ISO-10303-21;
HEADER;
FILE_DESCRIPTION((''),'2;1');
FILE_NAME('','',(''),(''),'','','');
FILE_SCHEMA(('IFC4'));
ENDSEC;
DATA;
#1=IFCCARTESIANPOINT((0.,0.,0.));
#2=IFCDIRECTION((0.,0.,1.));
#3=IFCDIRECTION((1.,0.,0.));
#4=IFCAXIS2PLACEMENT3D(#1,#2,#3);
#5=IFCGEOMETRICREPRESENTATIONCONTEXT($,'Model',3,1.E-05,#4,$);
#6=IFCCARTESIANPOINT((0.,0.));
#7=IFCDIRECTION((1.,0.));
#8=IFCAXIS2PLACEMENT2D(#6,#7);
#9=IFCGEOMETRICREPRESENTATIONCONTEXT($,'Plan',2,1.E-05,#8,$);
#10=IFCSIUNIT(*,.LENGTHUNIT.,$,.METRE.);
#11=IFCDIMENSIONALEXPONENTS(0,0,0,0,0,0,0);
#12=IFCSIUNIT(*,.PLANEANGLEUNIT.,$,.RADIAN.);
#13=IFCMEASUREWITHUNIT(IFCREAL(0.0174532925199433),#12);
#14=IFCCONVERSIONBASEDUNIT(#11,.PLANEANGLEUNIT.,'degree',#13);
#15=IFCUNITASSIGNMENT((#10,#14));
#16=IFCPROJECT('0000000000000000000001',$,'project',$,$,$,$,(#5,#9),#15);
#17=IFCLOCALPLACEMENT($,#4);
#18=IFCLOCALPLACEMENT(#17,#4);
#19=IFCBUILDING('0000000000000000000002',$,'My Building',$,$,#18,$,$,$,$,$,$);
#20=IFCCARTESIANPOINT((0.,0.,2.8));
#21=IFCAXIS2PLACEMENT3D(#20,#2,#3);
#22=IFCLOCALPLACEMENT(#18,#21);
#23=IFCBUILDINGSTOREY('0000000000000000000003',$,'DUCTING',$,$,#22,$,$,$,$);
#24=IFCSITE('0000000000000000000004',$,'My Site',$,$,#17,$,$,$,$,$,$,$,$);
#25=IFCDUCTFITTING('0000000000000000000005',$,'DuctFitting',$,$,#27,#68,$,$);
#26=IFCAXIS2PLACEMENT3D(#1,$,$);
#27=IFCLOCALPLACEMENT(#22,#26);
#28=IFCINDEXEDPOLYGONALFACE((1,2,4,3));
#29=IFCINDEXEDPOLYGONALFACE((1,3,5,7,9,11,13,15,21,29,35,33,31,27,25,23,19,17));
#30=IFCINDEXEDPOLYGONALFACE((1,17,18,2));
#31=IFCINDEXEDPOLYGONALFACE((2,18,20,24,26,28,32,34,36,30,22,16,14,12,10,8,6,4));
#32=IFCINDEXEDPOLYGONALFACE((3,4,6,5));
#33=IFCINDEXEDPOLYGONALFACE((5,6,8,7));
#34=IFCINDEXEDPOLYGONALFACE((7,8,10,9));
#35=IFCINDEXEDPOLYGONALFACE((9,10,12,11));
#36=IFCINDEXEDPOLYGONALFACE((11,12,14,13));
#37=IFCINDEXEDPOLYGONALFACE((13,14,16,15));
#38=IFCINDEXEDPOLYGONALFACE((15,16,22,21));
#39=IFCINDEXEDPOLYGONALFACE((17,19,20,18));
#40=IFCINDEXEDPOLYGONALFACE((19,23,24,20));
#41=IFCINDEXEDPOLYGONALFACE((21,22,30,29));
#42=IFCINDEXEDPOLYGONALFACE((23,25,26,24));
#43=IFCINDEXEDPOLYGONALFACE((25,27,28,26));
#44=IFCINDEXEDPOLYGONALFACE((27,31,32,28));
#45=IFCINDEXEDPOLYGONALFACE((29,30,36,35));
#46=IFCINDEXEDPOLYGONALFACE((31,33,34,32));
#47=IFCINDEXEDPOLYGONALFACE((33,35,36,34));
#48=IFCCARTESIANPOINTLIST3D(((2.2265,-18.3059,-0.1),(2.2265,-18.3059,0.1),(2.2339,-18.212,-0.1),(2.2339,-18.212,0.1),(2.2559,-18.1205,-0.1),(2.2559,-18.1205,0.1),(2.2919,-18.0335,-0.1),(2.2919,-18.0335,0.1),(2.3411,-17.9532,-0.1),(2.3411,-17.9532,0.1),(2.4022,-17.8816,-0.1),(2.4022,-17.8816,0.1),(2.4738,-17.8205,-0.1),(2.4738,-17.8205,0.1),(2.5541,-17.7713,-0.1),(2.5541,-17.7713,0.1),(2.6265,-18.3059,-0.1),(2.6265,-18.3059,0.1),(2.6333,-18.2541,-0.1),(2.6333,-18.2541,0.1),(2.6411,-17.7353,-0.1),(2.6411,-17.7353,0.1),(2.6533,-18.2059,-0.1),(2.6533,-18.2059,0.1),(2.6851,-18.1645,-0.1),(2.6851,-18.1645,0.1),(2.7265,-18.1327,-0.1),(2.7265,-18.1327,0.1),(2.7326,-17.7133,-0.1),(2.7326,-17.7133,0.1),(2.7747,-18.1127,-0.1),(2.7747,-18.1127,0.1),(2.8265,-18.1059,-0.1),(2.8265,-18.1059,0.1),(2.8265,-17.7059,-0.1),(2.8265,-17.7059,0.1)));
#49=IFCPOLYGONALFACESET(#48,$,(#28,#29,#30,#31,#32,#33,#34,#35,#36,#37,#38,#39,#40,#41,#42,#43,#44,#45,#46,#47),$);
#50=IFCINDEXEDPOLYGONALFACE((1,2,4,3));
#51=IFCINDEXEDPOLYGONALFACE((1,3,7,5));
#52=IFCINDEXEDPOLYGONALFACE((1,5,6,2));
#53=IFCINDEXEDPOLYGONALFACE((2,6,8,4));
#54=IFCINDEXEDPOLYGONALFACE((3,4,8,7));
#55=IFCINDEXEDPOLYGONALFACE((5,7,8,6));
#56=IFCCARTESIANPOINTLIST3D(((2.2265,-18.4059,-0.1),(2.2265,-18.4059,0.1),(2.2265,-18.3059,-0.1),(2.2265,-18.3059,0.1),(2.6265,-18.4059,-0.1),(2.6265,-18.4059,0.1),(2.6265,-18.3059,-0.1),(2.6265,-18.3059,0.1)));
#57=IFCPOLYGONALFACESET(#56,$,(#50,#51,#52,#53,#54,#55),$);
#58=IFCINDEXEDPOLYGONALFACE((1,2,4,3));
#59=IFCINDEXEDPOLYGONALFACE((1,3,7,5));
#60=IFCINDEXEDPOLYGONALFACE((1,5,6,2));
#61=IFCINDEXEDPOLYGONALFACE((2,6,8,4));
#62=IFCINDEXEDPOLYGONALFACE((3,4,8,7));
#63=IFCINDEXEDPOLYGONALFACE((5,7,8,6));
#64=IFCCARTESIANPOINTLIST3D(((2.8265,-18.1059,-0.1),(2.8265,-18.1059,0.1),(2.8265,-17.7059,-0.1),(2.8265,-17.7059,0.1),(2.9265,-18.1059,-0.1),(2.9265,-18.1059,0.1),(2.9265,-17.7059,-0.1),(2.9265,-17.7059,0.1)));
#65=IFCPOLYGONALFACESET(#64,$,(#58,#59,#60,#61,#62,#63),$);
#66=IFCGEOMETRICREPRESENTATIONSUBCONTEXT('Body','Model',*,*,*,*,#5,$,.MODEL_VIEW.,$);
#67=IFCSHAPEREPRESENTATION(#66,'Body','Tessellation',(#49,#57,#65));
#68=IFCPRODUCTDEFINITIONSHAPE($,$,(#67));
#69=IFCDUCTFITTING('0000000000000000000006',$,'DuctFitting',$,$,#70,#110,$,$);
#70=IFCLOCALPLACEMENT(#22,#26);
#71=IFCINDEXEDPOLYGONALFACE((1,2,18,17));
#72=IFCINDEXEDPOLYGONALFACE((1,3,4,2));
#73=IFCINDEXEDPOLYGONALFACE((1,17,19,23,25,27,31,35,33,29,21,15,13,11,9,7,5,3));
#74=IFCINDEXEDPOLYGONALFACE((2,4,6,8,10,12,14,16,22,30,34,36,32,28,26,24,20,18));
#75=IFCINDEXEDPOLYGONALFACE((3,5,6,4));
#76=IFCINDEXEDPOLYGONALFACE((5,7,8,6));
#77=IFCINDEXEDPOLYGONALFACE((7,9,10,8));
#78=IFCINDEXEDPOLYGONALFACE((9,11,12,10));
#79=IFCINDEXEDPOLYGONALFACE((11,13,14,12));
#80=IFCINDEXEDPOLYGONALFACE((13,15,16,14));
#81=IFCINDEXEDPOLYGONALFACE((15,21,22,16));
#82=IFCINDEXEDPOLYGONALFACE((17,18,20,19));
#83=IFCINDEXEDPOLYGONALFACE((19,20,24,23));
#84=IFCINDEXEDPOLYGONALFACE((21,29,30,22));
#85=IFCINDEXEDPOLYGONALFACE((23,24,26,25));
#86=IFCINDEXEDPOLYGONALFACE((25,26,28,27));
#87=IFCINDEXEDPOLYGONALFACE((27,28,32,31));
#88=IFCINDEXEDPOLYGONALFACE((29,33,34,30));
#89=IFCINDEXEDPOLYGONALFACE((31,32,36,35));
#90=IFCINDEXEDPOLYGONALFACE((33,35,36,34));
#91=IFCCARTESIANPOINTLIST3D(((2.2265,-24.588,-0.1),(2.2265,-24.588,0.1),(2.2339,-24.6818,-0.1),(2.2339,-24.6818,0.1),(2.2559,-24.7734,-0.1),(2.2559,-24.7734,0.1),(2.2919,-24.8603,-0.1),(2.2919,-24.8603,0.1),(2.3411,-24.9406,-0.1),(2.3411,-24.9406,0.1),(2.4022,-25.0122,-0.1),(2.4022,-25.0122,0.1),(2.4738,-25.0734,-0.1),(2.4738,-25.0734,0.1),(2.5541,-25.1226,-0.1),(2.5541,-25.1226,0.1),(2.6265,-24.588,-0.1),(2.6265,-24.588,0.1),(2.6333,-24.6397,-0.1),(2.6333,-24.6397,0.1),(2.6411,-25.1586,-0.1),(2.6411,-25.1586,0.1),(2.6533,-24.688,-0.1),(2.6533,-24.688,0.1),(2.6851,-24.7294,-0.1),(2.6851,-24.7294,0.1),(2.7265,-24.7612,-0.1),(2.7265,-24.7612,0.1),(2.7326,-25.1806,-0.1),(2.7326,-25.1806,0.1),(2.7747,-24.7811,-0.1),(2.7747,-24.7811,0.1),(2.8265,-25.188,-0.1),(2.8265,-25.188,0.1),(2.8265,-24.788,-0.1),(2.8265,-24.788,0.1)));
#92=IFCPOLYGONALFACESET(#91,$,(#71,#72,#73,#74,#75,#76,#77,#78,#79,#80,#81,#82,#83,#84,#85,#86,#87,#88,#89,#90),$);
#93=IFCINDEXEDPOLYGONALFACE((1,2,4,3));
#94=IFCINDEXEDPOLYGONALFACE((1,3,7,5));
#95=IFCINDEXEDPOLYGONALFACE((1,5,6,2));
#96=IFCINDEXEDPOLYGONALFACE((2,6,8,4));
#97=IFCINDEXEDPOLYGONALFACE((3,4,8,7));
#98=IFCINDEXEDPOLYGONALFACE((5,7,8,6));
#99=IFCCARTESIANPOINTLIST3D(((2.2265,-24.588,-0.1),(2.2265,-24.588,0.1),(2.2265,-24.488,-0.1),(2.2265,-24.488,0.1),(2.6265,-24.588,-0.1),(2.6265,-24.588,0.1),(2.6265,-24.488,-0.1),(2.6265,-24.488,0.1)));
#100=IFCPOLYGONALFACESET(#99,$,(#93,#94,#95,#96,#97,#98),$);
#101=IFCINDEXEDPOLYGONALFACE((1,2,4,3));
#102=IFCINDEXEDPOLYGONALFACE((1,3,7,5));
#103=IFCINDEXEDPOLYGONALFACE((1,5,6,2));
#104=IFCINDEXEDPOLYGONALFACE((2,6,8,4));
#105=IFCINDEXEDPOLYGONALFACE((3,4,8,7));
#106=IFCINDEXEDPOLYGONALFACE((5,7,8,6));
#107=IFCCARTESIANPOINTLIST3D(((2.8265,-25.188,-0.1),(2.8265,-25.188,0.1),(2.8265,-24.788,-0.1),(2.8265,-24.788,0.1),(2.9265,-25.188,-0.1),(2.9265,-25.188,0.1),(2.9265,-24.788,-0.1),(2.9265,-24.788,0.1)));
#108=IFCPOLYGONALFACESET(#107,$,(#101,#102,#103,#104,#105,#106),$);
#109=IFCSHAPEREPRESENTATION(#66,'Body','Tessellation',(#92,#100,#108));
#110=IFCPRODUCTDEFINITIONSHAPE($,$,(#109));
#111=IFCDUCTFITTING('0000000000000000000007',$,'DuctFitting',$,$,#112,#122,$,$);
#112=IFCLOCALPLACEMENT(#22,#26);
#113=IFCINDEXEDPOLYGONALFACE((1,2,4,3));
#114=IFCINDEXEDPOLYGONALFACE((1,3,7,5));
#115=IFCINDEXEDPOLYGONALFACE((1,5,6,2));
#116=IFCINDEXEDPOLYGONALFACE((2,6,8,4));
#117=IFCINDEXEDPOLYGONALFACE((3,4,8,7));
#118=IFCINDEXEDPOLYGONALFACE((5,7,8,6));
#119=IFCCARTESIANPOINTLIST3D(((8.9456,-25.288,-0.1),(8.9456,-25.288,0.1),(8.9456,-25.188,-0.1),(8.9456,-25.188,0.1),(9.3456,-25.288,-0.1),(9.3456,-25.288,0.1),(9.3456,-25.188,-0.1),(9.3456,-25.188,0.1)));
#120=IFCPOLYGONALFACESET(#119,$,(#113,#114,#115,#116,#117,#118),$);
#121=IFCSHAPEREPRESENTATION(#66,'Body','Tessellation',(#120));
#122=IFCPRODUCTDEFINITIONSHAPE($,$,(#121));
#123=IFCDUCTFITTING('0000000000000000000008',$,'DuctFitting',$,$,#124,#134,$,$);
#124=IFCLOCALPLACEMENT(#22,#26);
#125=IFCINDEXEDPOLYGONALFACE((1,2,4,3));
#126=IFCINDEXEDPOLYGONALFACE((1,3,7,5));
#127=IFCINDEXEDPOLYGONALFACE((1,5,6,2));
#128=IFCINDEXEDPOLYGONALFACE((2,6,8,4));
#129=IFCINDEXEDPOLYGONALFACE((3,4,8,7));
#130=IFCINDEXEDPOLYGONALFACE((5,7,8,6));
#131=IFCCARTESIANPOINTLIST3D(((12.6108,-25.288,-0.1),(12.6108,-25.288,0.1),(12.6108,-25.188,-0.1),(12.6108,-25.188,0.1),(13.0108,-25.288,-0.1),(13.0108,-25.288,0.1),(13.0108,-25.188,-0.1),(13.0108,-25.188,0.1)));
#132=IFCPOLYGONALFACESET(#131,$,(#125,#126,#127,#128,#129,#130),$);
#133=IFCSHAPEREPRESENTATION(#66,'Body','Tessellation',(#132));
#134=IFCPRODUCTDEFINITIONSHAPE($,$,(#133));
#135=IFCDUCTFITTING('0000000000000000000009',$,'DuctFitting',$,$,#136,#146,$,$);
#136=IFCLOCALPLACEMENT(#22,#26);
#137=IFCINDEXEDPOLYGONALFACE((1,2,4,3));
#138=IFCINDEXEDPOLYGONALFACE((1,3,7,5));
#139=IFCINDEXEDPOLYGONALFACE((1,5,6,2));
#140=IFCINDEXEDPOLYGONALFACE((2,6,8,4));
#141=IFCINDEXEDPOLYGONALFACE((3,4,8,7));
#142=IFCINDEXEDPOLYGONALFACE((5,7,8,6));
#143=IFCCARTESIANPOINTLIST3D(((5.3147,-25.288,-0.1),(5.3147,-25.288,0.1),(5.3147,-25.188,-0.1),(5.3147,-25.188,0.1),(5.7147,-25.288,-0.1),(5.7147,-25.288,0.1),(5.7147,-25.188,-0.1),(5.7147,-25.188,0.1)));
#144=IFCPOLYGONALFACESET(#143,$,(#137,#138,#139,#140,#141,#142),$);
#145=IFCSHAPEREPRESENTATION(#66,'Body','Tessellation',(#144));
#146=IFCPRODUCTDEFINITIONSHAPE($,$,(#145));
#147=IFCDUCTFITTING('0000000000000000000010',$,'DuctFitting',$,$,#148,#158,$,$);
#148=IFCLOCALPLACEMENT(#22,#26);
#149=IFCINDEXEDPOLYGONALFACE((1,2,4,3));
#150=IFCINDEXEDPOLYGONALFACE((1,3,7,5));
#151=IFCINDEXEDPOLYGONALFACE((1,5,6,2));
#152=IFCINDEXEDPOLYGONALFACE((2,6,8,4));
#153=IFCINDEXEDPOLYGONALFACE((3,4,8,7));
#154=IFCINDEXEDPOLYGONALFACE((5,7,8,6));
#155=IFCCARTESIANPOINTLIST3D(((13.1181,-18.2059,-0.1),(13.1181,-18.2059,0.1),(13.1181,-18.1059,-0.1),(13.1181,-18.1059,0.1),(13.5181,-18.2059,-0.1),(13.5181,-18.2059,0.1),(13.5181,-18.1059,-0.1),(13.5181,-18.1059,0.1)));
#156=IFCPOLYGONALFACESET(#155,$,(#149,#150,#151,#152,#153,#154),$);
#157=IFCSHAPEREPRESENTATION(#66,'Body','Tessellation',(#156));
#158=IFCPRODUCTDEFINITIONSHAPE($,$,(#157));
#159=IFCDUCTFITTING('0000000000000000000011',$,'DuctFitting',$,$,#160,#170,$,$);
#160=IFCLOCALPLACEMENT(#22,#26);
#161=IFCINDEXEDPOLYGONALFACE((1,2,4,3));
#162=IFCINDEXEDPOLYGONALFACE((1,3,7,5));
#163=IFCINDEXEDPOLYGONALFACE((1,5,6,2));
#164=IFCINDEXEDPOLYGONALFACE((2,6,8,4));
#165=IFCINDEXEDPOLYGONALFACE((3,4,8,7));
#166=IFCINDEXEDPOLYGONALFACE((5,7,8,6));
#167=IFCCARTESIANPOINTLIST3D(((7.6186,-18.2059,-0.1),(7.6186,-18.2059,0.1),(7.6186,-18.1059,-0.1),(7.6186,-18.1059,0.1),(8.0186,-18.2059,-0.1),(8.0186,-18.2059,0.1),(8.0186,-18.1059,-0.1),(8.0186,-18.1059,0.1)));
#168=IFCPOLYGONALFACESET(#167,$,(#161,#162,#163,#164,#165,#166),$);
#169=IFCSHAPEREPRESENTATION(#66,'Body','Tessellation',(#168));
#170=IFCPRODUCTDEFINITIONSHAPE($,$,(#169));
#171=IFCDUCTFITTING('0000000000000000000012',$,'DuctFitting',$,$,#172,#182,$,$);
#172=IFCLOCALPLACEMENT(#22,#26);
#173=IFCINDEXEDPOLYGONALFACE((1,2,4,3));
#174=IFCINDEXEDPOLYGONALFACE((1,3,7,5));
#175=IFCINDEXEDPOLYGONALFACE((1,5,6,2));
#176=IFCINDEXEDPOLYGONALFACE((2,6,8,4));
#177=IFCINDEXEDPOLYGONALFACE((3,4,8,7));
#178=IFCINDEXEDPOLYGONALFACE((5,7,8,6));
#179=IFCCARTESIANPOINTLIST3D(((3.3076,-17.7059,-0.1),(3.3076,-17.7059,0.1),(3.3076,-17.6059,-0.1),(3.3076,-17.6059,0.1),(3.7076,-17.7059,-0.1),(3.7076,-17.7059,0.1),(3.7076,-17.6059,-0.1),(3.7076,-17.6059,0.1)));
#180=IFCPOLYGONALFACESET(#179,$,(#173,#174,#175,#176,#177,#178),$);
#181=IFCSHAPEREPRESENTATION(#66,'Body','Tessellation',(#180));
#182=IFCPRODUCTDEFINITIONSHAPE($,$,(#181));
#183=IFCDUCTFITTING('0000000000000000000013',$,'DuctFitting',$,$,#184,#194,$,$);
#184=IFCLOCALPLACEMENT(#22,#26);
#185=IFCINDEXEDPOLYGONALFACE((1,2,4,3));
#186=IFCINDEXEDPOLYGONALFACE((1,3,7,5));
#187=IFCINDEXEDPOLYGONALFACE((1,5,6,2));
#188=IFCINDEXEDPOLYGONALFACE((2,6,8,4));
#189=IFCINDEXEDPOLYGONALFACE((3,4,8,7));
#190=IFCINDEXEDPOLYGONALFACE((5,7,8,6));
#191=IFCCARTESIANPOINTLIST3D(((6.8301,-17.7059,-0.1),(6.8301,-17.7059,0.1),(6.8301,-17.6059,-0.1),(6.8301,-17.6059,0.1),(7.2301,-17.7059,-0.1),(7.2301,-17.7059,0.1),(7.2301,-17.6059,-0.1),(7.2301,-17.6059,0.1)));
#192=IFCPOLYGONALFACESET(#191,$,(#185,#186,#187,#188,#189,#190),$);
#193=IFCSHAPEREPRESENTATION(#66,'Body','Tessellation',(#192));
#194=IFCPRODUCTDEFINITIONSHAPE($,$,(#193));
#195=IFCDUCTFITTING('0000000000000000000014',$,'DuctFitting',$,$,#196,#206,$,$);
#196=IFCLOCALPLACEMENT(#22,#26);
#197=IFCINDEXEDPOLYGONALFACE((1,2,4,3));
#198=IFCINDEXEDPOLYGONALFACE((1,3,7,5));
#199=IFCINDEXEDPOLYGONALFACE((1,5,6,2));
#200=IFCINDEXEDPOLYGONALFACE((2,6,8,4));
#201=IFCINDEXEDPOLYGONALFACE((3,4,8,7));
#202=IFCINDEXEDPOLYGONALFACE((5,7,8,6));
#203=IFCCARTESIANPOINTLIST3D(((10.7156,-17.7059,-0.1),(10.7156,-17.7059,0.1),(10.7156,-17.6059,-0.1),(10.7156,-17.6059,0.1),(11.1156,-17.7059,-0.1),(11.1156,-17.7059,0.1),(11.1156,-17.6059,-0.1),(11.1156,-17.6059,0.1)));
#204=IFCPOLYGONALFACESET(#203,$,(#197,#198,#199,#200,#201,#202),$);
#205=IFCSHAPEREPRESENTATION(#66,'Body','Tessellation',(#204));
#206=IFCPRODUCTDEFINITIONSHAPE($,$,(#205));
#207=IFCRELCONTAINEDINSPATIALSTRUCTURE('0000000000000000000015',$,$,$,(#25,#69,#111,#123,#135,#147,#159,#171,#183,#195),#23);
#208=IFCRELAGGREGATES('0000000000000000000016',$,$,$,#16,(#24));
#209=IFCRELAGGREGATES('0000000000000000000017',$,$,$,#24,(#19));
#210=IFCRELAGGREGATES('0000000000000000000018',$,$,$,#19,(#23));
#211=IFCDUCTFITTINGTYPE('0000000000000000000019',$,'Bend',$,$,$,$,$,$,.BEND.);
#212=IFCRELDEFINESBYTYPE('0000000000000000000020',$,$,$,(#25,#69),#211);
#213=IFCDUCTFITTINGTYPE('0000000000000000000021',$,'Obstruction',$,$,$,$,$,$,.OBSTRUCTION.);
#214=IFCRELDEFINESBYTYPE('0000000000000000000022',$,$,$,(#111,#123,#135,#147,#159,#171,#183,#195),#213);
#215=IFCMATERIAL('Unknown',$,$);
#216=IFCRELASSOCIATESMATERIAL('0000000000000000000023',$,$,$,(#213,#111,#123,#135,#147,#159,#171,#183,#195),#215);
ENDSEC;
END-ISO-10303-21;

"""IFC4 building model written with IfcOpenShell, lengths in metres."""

from ifc_helpers import new_model, entity, si_unit, converted_unit, frame, origin_with_axes, origin_2d_with_axis, place, context, subcontext, project, spatial, line, arc, indexed_curve, rectangle, outline, extrude, source, transform, mapped, material, material_profile, profile_set, profile_usage, type_object, type_shapes, element, save


model = new_model("IFC4")

# Units and contexts
model_context = context("Model", 3, precision=1e-05, world=origin_with_axes())
plan_context = context("Plan", 2, precision=1e-05, world=origin_2d_with_axis())
body_context = subcontext(model_context, "Body", "Model", "MODEL_VIEW")
ifc_project = project(units=[si_unit("LENGTHUNIT", "METRE"), converted_unit("PLANEANGLEUNIT", "degree", entity("IfcReal", 0.0174532925199433), si_unit("PLANEANGLEUNIT", "RADIAN"), dimensions=[0, 0, 0, 0, 0, 0, 0])], contexts=[model_context, plan_context])

# Site, building, storey
site_placement = place(None, origin_with_axes())
site = spatial("IfcSite", under=ifc_project, at=site_placement, Name="My Site")
building_placement = place(site_placement, origin_with_axes())
building = spatial("IfcBuilding", under=site, at=building_placement, Name="My Building")
storey_placement = place(building_placement, frame((0.0, 0.0, 2.8), z_axis=(0.0, 0.0, 1.0), x_axis=(1.0, 0.0, 0.0)))
storey = spatial("IfcBuildingStorey", under=building, at=storey_placement, Name="DUCTING")

# Shared definitions
ifc_material = material(Name="Unknown")

# Duct fittings
duct_fitting_type_1 = type_object("IfcDuctFittingType", Name="Bend", PredefinedType="BEND")
shared_shape = source(origin_with_axes(), body_context, "Body", "SweptSolid", [
    extrude(outline(indexed_curve([(-0.2, 0.0), (-0.2586, -0.1414), (-0.4, -0.2), (-0.4, -0.6), (0.0243, -0.4243), (0.2, 0.0)], segments=[arc(1, 2, 3), line(3, 4), arc(4, 5, 6), line(6, 1)])), frame((0.0, -0.1, -0.1), z_axis=(0.0, -1.0, 0.0), x_axis=(1.0, 0.0, 0.0)), (0.0, 0.0, -1.0), 0.2),
    extrude(rectangle(XDim=0.4, YDim=0.2), origin_with_axes(), (0.0, 0.0, -1.0), 0.1),
    extrude(rectangle(XDim=0.4, YDim=0.2), frame((-0.4, 0.0, -0.5), z_axis=(-1.0, 0.0, 0.0), x_axis=(0.0, 0.0, -1.0)), (0.0, 0.0, 1.0), 0.1),
])
type_shapes(duct_fitting_type_1, [shared_shape])
for number, where, z_axis, x_axis, name in (
    (1, (2.4265, -18.4059, 0.0), (0.0, -1.0, 0.0), (-1.0, 0.0, 0.0), "DuctFitting"),
    (2, (2.4265, -24.488, 0.0), (0.0, 1.0, 0.0), (-1.0, 0.0, 0.0), "DuctFitting"),
):
    element("IfcDuctFitting", number, at=place(storey_placement, frame(where, z_axis=z_axis, x_axis=x_axis)), inside=storey, type_object=duct_fitting_type_1, Name=name, context=body_context, shape_type="MappedRepresentation", body=[
        mapped(shared_shape, transform((0.0, 0.0, 0.0), x_axis=(1.0, 0.0, 0.0), y_axis=(0.0, 1.0, 0.0), z_axis=(0.0, 0.0, 1.0), scale=1.0)),
    ])
ifc_material_profile_1 = material_profile(ifc_material, rectangle(XDim=0.4, YDim=0.2))
ifc_profile_set_1 = profile_set([ifc_material_profile_1])
ifc_profile_usage_1 = profile_usage(ifc_profile_set_1, cardinal=5)
duct_fitting_type_2 = type_object("IfcDuctFittingType", Name="Obstruction", PredefinedType="OBSTRUCTION", material=ifc_profile_set_1)
duct_fitting_1_placement = place(storey_placement, frame((9.1456, -25.288, 0.0), z_axis=(0.0, 1.0, 0.0), x_axis=(1.0, 0.0, 0.0)))
element("IfcDuctFitting", 3, at=duct_fitting_1_placement, inside=storey, type_object=duct_fitting_type_2, material=ifc_profile_usage_1, Name="DuctFitting", context=body_context, shape_type="SweptSolid", body=[
    extrude(rectangle(XDim=0.4, YDim=0.2), origin_with_axes(), (0.0, 0.0, 1.0), 0.1),
])
ifc_profile_usage_2 = profile_usage(ifc_profile_set_1, cardinal=5)
duct_fitting_2_placement = place(storey_placement, frame((12.8108, -25.288, 0.0), z_axis=(0.0, 1.0, 0.0), x_axis=(1.0, 0.0, 0.0)))
element("IfcDuctFitting", 4, at=duct_fitting_2_placement, inside=storey, type_object=duct_fitting_type_2, material=ifc_profile_usage_2, Name="DuctFitting", context=body_context, shape_type="SweptSolid", body=[
    extrude(rectangle(XDim=0.4, YDim=0.2), origin_with_axes(), (0.0, 0.0, 1.0), 0.1),
])
ifc_profile_usage_3 = profile_usage(ifc_profile_set_1, cardinal=5)
duct_fitting_3_placement = place(storey_placement, frame((5.5147, -25.288, 0.0), z_axis=(0.0, 1.0, 0.0), x_axis=(1.0, 0.0, 0.0)))
element("IfcDuctFitting", 5, at=duct_fitting_3_placement, inside=storey, type_object=duct_fitting_type_2, material=ifc_profile_usage_3, Name="DuctFitting", context=body_context, shape_type="SweptSolid", body=[
    extrude(rectangle(XDim=0.4, YDim=0.2), origin_with_axes(), (0.0, 0.0, 1.0), 0.1),
])
ifc_profile_usage_4 = profile_usage(ifc_profile_set_1, cardinal=5)
duct_fitting_4_placement = place(storey_placement, frame((13.3181, -18.2059, 0.0), z_axis=(0.0, 1.0, 0.0), x_axis=(1.0, 0.0, 0.0)))
element("IfcDuctFitting", 6, at=duct_fitting_4_placement, inside=storey, type_object=duct_fitting_type_2, material=ifc_profile_usage_4, Name="DuctFitting", context=body_context, shape_type="SweptSolid", body=[
    extrude(rectangle(XDim=0.4, YDim=0.2), origin_with_axes(), (0.0, 0.0, 1.0), 0.1),
])
ifc_profile_usage_5 = profile_usage(ifc_profile_set_1, cardinal=5)
duct_fitting_5_placement = place(storey_placement, frame((7.8186, -18.2059, 0.0), z_axis=(0.0, 1.0, 0.0), x_axis=(1.0, 0.0, 0.0)))
element("IfcDuctFitting", 7, at=duct_fitting_5_placement, inside=storey, type_object=duct_fitting_type_2, material=ifc_profile_usage_5, Name="DuctFitting", context=body_context, shape_type="SweptSolid", body=[
    extrude(rectangle(XDim=0.4, YDim=0.2), origin_with_axes(), (0.0, 0.0, 1.0), 0.1),
])
ifc_profile_usage_6 = profile_usage(ifc_profile_set_1, cardinal=5)
duct_fitting_6_placement = place(storey_placement, frame((3.5076, -17.6059, 0.0), z_axis=(0.0, -1.0, 0.0), x_axis=(-1.0, 0.0, 0.0)))
element("IfcDuctFitting", 8, at=duct_fitting_6_placement, inside=storey, type_object=duct_fitting_type_2, material=ifc_profile_usage_6, Name="DuctFitting", context=body_context, shape_type="SweptSolid", body=[
    extrude(rectangle(XDim=0.4, YDim=0.2), origin_with_axes(), (0.0, 0.0, 1.0), 0.1),
])
ifc_profile_usage_7 = profile_usage(ifc_profile_set_1, cardinal=5)
duct_fitting_7_placement = place(storey_placement, frame((7.0301, -17.6059, 0.0), z_axis=(0.0, -1.0, 0.0), x_axis=(-1.0, 0.0, 0.0)))
element("IfcDuctFitting", 9, at=duct_fitting_7_placement, inside=storey, type_object=duct_fitting_type_2, material=ifc_profile_usage_7, Name="DuctFitting", context=body_context, shape_type="SweptSolid", body=[
    extrude(rectangle(XDim=0.4, YDim=0.2), origin_with_axes(), (0.0, 0.0, 1.0), 0.1),
])
ifc_profile_usage_8 = profile_usage(ifc_profile_set_1, cardinal=5)
duct_fitting_8_placement = place(storey_placement, frame((10.9156, -17.6059, 0.0), z_axis=(0.0, -1.0, 0.0), x_axis=(-1.0, 0.0, 0.0)))
element("IfcDuctFitting", 10, at=duct_fitting_8_placement, inside=storey, type_object=duct_fitting_type_2, material=ifc_profile_usage_8, Name="DuctFitting", context=body_context, shape_type="SweptSolid", body=[
    extrude(rectangle(XDim=0.4, YDim=0.2), origin_with_axes(), (0.0, 0.0, 1.0), 0.1),
])

save(model, "model.ifc")
